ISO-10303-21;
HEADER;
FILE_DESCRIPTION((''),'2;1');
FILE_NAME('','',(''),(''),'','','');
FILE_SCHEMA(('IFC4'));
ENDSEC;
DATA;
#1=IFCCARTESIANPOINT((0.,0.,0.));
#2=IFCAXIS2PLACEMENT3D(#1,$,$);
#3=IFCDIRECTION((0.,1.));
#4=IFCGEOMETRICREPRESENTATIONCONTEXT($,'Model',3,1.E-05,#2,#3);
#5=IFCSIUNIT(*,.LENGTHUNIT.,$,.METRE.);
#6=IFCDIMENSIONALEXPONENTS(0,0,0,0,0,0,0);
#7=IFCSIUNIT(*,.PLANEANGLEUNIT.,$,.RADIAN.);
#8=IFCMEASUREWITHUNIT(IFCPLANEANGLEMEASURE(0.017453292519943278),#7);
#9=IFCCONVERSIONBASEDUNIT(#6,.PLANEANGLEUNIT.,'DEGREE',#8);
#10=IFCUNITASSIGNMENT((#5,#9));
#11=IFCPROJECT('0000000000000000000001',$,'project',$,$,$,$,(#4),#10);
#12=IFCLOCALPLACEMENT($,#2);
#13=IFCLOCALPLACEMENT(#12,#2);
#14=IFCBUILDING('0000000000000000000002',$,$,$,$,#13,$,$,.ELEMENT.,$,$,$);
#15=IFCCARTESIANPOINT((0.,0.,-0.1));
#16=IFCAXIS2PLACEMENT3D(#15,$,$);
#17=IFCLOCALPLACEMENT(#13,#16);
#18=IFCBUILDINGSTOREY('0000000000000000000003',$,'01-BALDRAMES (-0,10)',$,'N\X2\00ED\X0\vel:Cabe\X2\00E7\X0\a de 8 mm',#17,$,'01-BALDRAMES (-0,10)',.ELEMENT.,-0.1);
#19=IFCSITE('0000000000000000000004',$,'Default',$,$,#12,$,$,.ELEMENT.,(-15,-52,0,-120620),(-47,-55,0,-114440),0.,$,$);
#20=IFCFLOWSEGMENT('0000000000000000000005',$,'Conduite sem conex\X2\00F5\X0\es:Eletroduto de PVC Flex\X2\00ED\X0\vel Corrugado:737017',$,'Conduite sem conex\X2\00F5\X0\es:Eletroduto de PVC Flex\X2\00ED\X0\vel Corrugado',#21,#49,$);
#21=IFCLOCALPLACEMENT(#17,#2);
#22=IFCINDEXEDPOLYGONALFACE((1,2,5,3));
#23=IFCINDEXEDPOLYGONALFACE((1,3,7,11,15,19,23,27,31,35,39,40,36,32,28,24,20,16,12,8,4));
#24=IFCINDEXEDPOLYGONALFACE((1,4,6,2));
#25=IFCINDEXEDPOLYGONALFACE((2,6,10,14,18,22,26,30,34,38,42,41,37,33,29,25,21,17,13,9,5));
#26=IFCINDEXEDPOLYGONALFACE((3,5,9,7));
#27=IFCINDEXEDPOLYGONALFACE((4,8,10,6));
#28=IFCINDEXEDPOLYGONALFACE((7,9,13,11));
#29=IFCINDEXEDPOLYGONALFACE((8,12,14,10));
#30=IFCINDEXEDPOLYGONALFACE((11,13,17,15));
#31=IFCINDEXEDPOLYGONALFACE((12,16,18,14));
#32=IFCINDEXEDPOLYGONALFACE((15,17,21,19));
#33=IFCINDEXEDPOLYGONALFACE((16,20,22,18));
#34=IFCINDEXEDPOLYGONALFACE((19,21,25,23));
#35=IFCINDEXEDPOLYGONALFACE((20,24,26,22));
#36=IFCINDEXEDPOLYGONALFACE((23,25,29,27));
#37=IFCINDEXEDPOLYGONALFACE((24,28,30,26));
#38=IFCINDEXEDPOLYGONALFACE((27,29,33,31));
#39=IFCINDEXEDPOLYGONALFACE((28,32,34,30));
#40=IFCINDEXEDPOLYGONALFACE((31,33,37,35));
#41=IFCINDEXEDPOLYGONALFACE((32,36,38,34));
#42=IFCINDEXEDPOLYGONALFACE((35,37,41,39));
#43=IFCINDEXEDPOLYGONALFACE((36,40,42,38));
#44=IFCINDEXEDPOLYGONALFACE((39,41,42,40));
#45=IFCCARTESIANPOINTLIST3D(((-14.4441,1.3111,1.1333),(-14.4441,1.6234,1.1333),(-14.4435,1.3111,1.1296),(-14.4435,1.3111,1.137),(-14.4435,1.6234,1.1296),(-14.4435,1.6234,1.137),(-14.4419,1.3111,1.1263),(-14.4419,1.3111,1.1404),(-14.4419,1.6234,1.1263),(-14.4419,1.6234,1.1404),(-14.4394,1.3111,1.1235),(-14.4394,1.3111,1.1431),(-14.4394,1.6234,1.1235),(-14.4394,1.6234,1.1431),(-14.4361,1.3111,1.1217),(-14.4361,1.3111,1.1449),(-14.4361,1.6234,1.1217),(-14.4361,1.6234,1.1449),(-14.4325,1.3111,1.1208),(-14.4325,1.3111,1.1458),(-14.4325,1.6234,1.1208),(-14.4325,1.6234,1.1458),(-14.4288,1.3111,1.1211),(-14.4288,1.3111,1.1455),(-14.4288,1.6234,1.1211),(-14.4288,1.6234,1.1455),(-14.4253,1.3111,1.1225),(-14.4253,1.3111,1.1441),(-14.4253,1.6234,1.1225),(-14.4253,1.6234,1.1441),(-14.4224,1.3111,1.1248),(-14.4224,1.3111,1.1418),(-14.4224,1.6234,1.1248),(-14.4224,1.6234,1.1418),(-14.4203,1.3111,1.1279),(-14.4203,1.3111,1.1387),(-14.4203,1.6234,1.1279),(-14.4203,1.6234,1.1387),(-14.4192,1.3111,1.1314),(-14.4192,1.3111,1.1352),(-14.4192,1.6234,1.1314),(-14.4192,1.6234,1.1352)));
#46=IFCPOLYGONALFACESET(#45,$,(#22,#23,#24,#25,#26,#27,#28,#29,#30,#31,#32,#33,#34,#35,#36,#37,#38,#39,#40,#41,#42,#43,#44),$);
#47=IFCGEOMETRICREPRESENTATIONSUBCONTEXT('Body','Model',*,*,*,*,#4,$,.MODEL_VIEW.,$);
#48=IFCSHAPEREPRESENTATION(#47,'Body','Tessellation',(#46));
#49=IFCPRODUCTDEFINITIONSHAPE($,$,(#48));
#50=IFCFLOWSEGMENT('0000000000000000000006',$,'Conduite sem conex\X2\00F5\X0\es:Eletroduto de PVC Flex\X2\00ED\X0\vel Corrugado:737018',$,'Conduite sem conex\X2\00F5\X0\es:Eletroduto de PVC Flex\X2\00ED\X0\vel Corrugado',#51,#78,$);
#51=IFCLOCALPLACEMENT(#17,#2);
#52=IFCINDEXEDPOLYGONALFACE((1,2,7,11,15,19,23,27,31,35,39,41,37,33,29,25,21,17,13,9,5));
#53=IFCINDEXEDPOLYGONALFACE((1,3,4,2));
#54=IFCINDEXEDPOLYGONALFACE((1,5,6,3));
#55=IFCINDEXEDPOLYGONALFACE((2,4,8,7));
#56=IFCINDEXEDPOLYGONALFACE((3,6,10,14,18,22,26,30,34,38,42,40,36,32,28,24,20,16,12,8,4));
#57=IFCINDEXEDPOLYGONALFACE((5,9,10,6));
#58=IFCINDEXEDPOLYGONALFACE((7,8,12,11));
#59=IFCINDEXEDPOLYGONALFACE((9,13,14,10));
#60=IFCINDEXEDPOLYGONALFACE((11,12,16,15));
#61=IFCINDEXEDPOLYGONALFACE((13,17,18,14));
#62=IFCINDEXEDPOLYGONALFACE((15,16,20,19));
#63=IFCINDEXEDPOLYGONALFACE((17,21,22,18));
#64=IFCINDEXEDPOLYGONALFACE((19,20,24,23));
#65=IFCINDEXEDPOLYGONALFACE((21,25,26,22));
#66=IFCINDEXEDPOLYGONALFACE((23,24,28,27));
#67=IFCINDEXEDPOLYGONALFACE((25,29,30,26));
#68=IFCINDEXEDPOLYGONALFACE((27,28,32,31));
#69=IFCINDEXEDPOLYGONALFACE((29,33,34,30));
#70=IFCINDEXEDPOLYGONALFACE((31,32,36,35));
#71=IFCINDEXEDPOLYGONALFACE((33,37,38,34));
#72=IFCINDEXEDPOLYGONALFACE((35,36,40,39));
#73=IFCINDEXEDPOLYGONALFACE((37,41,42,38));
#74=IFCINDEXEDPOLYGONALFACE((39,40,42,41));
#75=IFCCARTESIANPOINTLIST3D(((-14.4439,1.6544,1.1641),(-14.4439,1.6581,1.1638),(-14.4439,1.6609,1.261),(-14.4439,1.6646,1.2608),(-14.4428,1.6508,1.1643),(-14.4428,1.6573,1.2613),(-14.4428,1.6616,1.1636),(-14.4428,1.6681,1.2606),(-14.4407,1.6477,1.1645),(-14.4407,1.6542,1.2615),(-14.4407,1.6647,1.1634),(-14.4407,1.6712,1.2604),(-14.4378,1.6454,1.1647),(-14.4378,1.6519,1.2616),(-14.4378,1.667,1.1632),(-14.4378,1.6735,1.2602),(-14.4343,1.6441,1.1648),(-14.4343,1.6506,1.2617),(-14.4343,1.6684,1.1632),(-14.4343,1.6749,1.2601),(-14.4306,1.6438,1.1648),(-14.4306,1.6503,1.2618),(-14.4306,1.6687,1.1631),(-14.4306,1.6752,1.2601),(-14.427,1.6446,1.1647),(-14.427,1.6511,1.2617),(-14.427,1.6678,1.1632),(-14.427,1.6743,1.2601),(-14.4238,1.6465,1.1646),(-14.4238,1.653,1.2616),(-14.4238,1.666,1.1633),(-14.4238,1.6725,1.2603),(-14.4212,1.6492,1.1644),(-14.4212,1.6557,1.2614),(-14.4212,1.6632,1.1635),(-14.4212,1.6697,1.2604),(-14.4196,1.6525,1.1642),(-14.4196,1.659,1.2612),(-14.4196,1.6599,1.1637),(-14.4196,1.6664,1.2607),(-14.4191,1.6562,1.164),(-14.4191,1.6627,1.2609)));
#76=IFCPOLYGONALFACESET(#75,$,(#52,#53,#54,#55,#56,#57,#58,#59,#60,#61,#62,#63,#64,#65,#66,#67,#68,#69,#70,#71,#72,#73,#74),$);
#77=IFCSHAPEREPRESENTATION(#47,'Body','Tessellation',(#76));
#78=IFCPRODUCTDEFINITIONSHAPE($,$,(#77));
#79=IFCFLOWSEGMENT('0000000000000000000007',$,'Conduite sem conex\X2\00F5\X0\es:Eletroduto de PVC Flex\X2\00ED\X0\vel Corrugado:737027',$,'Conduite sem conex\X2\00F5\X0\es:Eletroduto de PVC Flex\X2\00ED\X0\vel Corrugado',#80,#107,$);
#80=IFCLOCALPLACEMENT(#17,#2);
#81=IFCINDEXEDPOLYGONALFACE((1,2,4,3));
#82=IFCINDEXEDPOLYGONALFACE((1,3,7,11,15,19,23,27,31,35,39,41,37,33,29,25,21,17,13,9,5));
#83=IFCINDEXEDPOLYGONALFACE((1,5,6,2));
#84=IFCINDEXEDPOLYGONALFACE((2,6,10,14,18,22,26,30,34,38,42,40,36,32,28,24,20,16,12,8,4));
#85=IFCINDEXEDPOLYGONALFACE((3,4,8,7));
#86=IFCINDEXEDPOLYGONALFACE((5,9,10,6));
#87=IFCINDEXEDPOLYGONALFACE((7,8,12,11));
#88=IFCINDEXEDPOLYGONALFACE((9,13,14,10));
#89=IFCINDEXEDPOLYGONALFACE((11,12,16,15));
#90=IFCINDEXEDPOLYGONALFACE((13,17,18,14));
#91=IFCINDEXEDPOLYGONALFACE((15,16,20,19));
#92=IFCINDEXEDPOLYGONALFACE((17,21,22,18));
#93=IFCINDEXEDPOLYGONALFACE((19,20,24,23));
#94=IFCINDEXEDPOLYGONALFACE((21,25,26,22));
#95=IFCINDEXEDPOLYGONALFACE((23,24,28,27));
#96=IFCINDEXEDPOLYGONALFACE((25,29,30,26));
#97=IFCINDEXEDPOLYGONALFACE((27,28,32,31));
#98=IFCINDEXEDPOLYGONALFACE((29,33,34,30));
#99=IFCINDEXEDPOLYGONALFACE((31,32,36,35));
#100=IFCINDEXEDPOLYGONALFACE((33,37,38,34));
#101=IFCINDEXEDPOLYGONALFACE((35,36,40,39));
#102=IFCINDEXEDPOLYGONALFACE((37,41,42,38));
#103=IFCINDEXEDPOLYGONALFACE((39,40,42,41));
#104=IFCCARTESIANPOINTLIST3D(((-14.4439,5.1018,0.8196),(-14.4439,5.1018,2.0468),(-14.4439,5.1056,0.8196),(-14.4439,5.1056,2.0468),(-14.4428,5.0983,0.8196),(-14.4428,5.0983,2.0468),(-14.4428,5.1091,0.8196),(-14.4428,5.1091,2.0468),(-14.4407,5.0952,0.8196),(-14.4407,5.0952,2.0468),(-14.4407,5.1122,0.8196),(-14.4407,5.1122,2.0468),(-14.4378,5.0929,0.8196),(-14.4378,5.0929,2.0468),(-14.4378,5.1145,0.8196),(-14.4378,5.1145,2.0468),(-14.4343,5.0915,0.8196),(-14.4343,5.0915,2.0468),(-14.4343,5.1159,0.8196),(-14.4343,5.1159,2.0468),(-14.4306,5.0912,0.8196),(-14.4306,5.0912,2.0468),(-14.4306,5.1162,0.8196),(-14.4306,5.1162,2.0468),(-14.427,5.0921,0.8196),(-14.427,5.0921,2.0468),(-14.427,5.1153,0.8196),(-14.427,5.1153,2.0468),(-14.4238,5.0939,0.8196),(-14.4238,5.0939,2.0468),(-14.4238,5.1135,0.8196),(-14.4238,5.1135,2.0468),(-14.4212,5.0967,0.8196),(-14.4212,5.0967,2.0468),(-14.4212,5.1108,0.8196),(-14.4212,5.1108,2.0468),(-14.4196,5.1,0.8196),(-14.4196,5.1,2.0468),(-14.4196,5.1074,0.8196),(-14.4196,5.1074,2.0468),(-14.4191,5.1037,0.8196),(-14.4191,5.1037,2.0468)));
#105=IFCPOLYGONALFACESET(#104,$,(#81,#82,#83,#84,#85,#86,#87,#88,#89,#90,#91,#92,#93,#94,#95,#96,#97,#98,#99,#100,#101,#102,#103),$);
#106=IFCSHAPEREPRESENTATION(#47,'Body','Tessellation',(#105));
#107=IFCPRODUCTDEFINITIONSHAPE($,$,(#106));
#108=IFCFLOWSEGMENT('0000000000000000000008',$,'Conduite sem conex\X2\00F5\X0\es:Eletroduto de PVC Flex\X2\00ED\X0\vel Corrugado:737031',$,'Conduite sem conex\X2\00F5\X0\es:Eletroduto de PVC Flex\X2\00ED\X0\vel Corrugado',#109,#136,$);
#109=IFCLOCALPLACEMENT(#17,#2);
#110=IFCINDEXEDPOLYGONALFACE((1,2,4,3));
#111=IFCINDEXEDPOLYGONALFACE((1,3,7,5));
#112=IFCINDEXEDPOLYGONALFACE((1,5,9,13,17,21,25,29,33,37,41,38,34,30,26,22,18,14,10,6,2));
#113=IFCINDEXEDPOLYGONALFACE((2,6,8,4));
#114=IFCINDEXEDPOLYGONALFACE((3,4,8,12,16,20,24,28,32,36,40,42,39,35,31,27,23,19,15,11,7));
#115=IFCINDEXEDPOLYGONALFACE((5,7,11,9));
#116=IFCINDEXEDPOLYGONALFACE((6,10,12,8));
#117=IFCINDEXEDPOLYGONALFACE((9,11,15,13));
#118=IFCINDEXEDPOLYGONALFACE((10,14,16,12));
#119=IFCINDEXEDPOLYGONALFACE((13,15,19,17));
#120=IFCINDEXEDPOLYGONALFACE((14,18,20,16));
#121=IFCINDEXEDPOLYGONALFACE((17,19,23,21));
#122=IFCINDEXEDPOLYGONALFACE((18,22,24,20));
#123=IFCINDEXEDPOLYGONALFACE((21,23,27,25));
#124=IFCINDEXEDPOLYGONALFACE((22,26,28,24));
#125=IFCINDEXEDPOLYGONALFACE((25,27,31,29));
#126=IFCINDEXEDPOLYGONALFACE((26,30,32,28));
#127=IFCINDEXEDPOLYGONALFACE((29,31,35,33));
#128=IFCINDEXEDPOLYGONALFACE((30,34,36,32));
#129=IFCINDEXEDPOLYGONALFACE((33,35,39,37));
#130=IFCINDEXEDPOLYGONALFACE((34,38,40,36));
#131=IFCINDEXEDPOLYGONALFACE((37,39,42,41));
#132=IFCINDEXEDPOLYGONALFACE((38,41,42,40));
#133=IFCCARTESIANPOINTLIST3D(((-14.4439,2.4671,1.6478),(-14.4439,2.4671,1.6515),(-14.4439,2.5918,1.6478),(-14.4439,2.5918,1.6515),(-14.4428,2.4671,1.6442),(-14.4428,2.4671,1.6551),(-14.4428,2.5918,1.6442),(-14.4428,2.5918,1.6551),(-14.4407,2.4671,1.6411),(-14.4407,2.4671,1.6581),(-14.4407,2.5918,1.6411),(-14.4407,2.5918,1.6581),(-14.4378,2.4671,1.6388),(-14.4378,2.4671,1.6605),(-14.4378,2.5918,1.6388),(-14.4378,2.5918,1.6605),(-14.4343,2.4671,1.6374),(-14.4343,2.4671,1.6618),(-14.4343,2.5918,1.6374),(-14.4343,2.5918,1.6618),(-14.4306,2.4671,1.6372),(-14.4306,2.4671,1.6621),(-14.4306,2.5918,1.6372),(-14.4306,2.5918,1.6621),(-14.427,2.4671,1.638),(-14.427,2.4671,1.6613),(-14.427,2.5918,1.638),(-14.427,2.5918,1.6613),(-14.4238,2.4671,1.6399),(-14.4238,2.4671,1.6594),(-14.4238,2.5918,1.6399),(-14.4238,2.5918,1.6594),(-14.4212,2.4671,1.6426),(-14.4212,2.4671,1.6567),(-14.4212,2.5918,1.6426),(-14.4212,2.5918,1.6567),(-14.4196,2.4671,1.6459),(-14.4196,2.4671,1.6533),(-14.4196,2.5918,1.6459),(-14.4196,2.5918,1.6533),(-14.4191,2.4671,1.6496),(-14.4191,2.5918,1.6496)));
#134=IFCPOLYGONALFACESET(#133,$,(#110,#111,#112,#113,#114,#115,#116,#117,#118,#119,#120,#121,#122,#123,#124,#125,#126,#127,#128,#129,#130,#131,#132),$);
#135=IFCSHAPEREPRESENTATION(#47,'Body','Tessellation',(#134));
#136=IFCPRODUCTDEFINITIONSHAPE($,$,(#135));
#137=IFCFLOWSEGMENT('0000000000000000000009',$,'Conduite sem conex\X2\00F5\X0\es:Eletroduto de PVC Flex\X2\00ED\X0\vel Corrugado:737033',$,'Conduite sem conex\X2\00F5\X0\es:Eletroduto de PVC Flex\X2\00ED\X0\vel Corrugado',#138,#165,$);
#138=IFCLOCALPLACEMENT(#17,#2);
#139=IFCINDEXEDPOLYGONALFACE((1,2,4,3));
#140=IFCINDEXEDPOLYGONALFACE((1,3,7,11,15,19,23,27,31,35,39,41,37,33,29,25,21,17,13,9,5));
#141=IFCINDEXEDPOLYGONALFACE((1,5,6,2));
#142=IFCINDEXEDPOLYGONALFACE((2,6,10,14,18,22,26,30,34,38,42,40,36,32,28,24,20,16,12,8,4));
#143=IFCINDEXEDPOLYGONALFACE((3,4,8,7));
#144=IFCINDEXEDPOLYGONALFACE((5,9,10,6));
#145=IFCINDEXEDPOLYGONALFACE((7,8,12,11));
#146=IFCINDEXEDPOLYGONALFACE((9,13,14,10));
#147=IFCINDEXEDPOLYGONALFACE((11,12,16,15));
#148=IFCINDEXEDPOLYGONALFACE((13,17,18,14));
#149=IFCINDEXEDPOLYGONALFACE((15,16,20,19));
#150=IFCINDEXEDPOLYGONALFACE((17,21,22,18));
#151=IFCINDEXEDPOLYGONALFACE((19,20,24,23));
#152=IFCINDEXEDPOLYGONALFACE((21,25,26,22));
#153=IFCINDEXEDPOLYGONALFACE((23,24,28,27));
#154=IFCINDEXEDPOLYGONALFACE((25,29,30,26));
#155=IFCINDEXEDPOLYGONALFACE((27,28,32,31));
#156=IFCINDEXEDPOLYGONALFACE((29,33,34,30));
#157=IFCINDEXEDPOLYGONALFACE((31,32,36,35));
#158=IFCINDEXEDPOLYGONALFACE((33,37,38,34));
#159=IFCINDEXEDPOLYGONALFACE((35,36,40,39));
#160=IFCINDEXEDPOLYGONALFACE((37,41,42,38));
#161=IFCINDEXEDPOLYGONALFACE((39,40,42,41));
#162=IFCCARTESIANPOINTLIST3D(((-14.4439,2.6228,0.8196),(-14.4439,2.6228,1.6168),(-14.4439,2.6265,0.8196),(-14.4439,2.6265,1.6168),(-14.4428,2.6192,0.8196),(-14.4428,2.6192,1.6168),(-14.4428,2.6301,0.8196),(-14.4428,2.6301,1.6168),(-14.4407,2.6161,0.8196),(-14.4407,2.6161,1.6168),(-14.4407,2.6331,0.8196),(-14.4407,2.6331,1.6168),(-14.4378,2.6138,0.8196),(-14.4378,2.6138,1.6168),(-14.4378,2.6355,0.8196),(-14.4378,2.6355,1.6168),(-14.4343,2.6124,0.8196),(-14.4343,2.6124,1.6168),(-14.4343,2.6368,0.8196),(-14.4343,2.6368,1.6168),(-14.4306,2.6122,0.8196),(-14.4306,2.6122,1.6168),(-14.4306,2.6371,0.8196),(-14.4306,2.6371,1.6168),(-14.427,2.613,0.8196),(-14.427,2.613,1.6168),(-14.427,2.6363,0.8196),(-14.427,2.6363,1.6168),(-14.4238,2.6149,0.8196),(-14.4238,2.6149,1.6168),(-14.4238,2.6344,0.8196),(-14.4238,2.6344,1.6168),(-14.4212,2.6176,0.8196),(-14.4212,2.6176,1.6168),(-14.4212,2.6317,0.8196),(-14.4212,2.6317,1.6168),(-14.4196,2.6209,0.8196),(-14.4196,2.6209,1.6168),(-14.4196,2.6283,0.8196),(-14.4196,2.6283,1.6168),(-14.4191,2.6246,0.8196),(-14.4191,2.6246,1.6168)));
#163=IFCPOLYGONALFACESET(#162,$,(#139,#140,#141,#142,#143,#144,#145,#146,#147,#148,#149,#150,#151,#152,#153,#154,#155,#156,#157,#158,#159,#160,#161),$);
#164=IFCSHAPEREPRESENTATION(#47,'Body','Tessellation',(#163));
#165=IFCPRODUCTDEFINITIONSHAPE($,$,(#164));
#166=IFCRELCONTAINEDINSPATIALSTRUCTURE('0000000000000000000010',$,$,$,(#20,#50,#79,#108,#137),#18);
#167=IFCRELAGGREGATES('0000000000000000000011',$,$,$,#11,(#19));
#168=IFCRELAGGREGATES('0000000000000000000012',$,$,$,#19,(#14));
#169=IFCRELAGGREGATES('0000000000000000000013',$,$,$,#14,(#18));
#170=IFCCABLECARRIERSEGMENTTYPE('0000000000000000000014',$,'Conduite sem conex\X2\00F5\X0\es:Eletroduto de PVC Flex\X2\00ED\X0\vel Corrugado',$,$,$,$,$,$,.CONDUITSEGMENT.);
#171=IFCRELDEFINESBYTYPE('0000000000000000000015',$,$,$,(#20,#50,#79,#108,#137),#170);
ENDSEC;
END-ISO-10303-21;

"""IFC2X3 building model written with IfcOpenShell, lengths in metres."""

from ifc_helpers import new_model, entity, si_unit, converted_unit, direction, frame, frame_2d, origin, origin_2d_with_axis, place, context, subcontext, project, spatial, circle, extrude, type_object, element, save


model = new_model("IFC2X3")

# Units and contexts
model_context = context("Model", 3, precision=1e-05, world=origin(), true_north=direction((0.0, 1.0)))
body_context = subcontext(model_context, "Body", "Model", "MODEL_VIEW")
ifc_project = project(units=[si_unit("LENGTHUNIT", "METRE"), converted_unit("PLANEANGLEUNIT", "DEGREE", entity("IfcPlaneAngleMeasure", 0.017453292519943278), si_unit("PLANEANGLEUNIT", "RADIAN"), dimensions=[0, 0, 0, 0, 0, 0, 0])], contexts=[model_context])

# Site, building, storey
site_placement = place(None, origin())
site = spatial("IfcSite", under=ifc_project, at=site_placement, Name="Default", CompositionType="ELEMENT", RefLatitude=(-15, -52, 0, -120620), RefLongitude=(-47, -55, 0, -114440), RefElevation=0.0)
building_placement = place(site_placement, origin())
building = spatial("IfcBuilding", under=site, at=building_placement, CompositionType="ELEMENT")
storey_placement = place(building_placement, frame((0.0, 0.0, -0.1)))
storey = spatial("IfcBuildingStorey", under=building, at=storey_placement, Name="01-BALDRAMES (-0,10)", ObjectType="Nível:Cabeça de 8 mm", LongName="01-BALDRAMES (-0,10)", CompositionType="ELEMENT", Elevation=-0.1)

# Flow segments
cable_carrier_segment_type = type_object("IfcCableCarrierSegmentType", Name="Conduite sem conexões:Eletroduto de PVC Flexível Corrugado", PredefinedType="CONDUITSEGMENT")
flow_segment_1_placement = place(storey_placement, origin())
element("IfcFlowSegment", 1, at=flow_segment_1_placement, inside=storey, type_object=cable_carrier_segment_type, Name="Conduite sem conexões:Eletroduto de PVC Flexível Corrugado:737017", ObjectType="Conduite sem conexões:Eletroduto de PVC Flexível Corrugado", context=body_context, shape_type="SweptSolid", body=[
    extrude(circle(Radius=0.0125, at=frame_2d((0.0, 0.0), x_axis=(1.0, 0.0))), frame((-14.4316, 1.3111, 1.1333), z_axis=(0.000002, 1.0, 0.0), x_axis=(-1.0, 0.000002, 0.0)), (0.0, 0.0, 1.0), 0.3123),
])
flow_segment_2_placement = place(storey_placement, origin())
element("IfcFlowSegment", 2, at=flow_segment_2_placement, inside=storey, type_object=cable_carrier_segment_type, Name="Conduite sem conexões:Eletroduto de PVC Flexível Corrugado:737018", ObjectType="Conduite sem conexões:Eletroduto de PVC Flexível Corrugado", context=body_context, shape_type="SweptSolid", body=[
    extrude(circle(Radius=0.0125, at=frame_2d((0.0, 0.0), x_axis=(1.0, 0.0))), frame((-14.4316, 1.6562, 1.164), z_axis=(0.0, 0.066923, 0.997758), x_axis=(1.0, 0.000004, 0.0)), (0.0, 0.0, 1.0), 0.0972),
])
flow_segment_3_placement = place(storey_placement, origin())
element("IfcFlowSegment", 3, at=flow_segment_3_placement, inside=storey, type_object=cable_carrier_segment_type, Name="Conduite sem conexões:Eletroduto de PVC Flexível Corrugado:737027", ObjectType="Conduite sem conexões:Eletroduto de PVC Flexível Corrugado", context=body_context, shape_type="SweptSolid", body=[
    extrude(circle(Radius=0.0125, at=frame_2d((0.0, 0.0), x_axis=(1.0, 0.0))), frame((-14.4316, 5.1037, 0.8196)), (0.0, 0.0, 1.0), 1.2272),
])
flow_segment_4_placement = place(storey_placement, origin())
element("IfcFlowSegment", 4, at=flow_segment_4_placement, inside=storey, type_object=cable_carrier_segment_type, Name="Conduite sem conexões:Eletroduto de PVC Flexível Corrugado:737031", ObjectType="Conduite sem conexões:Eletroduto de PVC Flexível Corrugado", context=body_context, shape_type="SweptSolid", body=[
    extrude(circle(Radius=0.0125, at=frame_2d((0.0, 0.0), x_axis=(1.0, 0.0))), frame((-14.4316, 2.4671, 1.6496), z_axis=(0.0, 1.0, 0.0), x_axis=(1.0, 0.0, 0.0)), (0.0, 0.0, 1.0), 0.1247),
])
flow_segment_5_placement = place(storey_placement, origin())
element("IfcFlowSegment", 5, at=flow_segment_5_placement, inside=storey, type_object=cable_carrier_segment_type, Name="Conduite sem conexões:Eletroduto de PVC Flexível Corrugado:737033", ObjectType="Conduite sem conexões:Eletroduto de PVC Flexível Corrugado", context=body_context, shape_type="SweptSolid", body=[
    extrude(circle(Radius=0.0125, at=origin_2d_with_axis()), frame((-14.4316, 2.6246, 0.8196)), (0.0, 0.0, 1.0), 0.7972),
])

save(model, "model.ifc")
